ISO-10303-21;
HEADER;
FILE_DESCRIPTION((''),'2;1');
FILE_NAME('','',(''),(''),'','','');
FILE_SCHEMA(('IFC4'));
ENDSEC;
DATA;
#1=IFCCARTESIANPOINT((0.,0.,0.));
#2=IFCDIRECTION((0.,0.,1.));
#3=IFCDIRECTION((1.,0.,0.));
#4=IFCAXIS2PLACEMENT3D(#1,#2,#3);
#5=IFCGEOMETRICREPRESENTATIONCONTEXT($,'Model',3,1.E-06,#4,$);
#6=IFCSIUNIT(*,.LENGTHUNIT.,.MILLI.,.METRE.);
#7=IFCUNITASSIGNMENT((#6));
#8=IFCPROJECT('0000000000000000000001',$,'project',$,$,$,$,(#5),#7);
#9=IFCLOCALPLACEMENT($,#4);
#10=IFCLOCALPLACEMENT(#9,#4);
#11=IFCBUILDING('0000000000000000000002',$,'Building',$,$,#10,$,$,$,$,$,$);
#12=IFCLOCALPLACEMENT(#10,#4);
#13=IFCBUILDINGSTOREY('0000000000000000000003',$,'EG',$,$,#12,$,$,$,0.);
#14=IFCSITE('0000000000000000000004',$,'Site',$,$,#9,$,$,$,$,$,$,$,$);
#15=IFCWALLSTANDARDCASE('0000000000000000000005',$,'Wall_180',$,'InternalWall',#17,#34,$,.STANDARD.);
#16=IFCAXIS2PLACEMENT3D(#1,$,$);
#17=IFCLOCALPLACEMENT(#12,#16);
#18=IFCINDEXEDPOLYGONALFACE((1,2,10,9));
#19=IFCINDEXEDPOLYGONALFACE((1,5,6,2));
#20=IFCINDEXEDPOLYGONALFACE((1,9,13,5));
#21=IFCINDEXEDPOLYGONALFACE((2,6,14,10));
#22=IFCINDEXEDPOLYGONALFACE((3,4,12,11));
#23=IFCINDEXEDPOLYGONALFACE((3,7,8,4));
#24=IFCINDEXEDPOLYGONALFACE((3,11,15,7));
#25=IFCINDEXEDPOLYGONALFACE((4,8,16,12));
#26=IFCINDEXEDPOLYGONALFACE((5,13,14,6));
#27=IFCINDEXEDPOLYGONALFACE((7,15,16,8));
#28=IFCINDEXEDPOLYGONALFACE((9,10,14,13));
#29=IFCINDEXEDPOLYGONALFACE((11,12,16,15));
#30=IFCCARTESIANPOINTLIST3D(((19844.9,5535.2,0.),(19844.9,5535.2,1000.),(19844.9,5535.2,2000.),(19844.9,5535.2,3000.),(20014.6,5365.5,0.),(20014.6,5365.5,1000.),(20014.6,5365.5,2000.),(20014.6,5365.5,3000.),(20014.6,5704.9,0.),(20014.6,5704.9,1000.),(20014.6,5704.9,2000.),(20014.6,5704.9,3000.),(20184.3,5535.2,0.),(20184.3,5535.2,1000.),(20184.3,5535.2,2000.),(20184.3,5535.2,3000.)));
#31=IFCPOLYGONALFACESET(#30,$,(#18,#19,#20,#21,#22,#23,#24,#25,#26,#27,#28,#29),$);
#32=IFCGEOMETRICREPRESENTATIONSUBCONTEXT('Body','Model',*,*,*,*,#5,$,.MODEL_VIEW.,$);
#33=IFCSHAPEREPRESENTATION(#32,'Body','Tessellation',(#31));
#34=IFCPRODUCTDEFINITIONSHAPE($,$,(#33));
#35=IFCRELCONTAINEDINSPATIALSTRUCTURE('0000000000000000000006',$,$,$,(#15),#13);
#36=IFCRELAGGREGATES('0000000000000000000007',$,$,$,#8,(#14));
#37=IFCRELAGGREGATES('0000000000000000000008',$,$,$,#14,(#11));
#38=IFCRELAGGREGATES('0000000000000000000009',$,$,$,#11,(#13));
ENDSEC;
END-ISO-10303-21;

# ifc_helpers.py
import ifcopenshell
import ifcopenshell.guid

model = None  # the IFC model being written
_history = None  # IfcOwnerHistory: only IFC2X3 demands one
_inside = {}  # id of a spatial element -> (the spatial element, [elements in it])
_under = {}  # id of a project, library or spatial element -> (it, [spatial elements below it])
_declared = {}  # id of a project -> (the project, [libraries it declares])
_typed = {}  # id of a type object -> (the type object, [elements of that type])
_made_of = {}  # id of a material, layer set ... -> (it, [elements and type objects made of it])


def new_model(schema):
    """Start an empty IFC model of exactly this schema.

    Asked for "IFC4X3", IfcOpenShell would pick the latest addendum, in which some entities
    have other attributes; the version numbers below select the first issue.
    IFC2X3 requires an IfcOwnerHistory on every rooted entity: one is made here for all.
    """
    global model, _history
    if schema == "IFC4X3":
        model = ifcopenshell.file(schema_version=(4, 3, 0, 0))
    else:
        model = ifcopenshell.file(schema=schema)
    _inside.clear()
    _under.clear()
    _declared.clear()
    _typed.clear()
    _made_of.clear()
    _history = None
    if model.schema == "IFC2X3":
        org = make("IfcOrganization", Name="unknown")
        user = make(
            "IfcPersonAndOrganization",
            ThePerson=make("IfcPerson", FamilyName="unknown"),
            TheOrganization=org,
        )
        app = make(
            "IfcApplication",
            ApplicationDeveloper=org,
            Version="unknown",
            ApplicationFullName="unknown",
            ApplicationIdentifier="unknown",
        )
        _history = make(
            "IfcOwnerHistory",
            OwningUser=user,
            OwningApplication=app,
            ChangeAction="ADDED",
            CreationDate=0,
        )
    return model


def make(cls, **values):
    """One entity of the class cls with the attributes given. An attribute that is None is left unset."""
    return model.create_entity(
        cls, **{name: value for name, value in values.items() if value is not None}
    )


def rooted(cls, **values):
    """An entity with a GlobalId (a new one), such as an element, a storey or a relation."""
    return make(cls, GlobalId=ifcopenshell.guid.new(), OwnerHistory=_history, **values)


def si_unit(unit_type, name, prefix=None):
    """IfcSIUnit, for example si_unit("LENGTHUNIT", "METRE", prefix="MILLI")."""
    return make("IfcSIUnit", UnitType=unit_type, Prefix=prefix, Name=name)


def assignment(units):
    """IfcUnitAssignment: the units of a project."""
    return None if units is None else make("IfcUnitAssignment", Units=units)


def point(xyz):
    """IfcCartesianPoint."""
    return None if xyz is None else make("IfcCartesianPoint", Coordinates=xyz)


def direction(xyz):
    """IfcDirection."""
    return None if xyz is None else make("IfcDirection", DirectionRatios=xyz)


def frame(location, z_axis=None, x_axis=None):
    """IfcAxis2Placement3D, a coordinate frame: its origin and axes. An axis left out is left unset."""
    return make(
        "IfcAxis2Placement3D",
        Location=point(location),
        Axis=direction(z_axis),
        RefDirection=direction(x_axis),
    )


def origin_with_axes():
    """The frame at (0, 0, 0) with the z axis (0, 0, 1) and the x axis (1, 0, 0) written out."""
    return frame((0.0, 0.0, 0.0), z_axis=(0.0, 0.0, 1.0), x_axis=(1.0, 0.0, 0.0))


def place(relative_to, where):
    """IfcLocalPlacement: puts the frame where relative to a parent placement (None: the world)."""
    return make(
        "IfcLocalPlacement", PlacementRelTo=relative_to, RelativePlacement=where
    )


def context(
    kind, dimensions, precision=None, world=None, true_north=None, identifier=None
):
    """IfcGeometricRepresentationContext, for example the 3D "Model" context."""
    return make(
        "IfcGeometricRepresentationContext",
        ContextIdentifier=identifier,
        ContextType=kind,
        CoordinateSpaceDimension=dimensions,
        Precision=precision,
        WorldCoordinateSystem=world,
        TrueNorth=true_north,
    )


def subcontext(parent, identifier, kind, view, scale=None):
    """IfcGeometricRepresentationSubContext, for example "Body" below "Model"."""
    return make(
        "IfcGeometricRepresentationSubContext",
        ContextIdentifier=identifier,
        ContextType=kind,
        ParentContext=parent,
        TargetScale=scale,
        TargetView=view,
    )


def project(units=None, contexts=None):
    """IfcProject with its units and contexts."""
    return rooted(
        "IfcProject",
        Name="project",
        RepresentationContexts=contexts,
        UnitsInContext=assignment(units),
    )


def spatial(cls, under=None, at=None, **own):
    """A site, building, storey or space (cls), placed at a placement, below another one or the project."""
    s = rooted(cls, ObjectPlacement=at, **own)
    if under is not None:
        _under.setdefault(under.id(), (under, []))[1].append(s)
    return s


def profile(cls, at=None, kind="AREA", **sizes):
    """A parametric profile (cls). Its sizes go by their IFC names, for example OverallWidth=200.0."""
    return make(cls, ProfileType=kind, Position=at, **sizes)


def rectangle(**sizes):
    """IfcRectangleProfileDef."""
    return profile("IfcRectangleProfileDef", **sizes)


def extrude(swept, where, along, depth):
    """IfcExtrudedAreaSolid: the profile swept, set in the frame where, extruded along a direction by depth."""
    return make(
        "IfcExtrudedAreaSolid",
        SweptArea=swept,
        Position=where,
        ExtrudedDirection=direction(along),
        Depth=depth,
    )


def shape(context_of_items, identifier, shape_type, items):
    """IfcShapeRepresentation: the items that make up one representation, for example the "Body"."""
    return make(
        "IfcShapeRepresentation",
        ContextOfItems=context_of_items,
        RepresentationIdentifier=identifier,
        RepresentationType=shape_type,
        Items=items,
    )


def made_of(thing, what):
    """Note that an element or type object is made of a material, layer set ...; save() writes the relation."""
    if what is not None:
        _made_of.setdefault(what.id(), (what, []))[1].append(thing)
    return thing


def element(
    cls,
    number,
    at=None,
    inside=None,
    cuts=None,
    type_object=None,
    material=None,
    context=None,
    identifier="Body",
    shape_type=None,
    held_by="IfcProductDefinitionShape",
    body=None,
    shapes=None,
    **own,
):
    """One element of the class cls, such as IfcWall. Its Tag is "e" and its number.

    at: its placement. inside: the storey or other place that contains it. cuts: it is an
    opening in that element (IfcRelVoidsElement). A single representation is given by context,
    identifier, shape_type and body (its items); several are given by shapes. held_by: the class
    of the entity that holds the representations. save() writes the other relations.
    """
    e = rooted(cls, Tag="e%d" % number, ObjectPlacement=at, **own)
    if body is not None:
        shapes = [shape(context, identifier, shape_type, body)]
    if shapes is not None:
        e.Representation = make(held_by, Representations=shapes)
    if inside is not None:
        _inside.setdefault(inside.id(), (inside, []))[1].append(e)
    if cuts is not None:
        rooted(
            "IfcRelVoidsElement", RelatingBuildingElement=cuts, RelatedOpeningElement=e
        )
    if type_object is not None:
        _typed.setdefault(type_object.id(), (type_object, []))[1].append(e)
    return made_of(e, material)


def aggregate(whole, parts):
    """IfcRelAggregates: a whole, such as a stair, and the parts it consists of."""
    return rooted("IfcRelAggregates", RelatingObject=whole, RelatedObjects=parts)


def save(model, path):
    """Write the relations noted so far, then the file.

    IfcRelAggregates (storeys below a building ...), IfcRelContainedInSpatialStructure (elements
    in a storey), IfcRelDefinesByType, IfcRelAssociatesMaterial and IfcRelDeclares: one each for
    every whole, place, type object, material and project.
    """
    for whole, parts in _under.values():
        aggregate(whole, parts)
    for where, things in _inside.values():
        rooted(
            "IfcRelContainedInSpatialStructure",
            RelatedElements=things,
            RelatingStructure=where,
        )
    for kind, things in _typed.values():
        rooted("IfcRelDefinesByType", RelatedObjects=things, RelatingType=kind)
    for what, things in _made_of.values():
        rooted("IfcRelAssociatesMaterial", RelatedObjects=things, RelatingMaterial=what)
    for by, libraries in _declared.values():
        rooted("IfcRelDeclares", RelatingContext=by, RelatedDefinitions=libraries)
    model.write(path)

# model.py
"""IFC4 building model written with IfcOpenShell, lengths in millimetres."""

from ifc_helpers import new_model, si_unit, frame, origin_with_axes, place, context, subcontext, project, spatial, rectangle, extrude, element, save


model = new_model("IFC4")

# Units and contexts
model_context = context("Model", 3, precision=1e-06, world=origin_with_axes())
body_context = subcontext(model_context, "Body", "Model", "MODEL_VIEW")
ifc_project = project(units=[si_unit("LENGTHUNIT", "METRE", prefix="MILLI")], contexts=[model_context])

# Site, building, storey
site_placement = place(None, origin_with_axes())
site = spatial("IfcSite", under=ifc_project, at=site_placement, Name="Site")
building_placement = place(site_placement, origin_with_axes())
building = spatial("IfcBuilding", under=site, at=building_placement, Name="Building")
storey_placement = place(building_placement, origin_with_axes())
storey = spatial("IfcBuildingStorey", under=building, at=storey_placement, Name="EG", Elevation=0.0)

# Wall, opening
wall_1_placement = place(storey_placement, origin_with_axes())
wall_1 = element("IfcWallStandardCase", 1, at=wall_1_placement, inside=storey, Name="Wall_180", ObjectType="InternalWall", PredefinedType="STANDARD", context=body_context, shape_type="SweptSolid", body=[
    extrude(rectangle(XDim=240.0, YDim=240.0), frame((20014.6, 5535.2, 0.0), z_axis=(0.0, 0.0, 1.0), x_axis=(0.707107, -0.707107, 0.0)), (0.0, 0.0, 1.0), 3000.0),
])
opening_1_placement = place(wall_1_placement, origin_with_axes())
element("IfcOpeningElement", 2, at=opening_1_placement, inside=storey, cuts=wall_1, context=body_context, shape_type="SweptSolid", body=[
    extrude(rectangle(XDim=600.0, YDim=240.0), frame((20014.6, 5535.2, 1000.0), z_axis=(0.0, 0.0, 1.0), x_axis=(0.707107, -0.707107, 0.0)), (0.0, 0.0, 1.0), 1000.0),
])

save(model, "model.ifc")
